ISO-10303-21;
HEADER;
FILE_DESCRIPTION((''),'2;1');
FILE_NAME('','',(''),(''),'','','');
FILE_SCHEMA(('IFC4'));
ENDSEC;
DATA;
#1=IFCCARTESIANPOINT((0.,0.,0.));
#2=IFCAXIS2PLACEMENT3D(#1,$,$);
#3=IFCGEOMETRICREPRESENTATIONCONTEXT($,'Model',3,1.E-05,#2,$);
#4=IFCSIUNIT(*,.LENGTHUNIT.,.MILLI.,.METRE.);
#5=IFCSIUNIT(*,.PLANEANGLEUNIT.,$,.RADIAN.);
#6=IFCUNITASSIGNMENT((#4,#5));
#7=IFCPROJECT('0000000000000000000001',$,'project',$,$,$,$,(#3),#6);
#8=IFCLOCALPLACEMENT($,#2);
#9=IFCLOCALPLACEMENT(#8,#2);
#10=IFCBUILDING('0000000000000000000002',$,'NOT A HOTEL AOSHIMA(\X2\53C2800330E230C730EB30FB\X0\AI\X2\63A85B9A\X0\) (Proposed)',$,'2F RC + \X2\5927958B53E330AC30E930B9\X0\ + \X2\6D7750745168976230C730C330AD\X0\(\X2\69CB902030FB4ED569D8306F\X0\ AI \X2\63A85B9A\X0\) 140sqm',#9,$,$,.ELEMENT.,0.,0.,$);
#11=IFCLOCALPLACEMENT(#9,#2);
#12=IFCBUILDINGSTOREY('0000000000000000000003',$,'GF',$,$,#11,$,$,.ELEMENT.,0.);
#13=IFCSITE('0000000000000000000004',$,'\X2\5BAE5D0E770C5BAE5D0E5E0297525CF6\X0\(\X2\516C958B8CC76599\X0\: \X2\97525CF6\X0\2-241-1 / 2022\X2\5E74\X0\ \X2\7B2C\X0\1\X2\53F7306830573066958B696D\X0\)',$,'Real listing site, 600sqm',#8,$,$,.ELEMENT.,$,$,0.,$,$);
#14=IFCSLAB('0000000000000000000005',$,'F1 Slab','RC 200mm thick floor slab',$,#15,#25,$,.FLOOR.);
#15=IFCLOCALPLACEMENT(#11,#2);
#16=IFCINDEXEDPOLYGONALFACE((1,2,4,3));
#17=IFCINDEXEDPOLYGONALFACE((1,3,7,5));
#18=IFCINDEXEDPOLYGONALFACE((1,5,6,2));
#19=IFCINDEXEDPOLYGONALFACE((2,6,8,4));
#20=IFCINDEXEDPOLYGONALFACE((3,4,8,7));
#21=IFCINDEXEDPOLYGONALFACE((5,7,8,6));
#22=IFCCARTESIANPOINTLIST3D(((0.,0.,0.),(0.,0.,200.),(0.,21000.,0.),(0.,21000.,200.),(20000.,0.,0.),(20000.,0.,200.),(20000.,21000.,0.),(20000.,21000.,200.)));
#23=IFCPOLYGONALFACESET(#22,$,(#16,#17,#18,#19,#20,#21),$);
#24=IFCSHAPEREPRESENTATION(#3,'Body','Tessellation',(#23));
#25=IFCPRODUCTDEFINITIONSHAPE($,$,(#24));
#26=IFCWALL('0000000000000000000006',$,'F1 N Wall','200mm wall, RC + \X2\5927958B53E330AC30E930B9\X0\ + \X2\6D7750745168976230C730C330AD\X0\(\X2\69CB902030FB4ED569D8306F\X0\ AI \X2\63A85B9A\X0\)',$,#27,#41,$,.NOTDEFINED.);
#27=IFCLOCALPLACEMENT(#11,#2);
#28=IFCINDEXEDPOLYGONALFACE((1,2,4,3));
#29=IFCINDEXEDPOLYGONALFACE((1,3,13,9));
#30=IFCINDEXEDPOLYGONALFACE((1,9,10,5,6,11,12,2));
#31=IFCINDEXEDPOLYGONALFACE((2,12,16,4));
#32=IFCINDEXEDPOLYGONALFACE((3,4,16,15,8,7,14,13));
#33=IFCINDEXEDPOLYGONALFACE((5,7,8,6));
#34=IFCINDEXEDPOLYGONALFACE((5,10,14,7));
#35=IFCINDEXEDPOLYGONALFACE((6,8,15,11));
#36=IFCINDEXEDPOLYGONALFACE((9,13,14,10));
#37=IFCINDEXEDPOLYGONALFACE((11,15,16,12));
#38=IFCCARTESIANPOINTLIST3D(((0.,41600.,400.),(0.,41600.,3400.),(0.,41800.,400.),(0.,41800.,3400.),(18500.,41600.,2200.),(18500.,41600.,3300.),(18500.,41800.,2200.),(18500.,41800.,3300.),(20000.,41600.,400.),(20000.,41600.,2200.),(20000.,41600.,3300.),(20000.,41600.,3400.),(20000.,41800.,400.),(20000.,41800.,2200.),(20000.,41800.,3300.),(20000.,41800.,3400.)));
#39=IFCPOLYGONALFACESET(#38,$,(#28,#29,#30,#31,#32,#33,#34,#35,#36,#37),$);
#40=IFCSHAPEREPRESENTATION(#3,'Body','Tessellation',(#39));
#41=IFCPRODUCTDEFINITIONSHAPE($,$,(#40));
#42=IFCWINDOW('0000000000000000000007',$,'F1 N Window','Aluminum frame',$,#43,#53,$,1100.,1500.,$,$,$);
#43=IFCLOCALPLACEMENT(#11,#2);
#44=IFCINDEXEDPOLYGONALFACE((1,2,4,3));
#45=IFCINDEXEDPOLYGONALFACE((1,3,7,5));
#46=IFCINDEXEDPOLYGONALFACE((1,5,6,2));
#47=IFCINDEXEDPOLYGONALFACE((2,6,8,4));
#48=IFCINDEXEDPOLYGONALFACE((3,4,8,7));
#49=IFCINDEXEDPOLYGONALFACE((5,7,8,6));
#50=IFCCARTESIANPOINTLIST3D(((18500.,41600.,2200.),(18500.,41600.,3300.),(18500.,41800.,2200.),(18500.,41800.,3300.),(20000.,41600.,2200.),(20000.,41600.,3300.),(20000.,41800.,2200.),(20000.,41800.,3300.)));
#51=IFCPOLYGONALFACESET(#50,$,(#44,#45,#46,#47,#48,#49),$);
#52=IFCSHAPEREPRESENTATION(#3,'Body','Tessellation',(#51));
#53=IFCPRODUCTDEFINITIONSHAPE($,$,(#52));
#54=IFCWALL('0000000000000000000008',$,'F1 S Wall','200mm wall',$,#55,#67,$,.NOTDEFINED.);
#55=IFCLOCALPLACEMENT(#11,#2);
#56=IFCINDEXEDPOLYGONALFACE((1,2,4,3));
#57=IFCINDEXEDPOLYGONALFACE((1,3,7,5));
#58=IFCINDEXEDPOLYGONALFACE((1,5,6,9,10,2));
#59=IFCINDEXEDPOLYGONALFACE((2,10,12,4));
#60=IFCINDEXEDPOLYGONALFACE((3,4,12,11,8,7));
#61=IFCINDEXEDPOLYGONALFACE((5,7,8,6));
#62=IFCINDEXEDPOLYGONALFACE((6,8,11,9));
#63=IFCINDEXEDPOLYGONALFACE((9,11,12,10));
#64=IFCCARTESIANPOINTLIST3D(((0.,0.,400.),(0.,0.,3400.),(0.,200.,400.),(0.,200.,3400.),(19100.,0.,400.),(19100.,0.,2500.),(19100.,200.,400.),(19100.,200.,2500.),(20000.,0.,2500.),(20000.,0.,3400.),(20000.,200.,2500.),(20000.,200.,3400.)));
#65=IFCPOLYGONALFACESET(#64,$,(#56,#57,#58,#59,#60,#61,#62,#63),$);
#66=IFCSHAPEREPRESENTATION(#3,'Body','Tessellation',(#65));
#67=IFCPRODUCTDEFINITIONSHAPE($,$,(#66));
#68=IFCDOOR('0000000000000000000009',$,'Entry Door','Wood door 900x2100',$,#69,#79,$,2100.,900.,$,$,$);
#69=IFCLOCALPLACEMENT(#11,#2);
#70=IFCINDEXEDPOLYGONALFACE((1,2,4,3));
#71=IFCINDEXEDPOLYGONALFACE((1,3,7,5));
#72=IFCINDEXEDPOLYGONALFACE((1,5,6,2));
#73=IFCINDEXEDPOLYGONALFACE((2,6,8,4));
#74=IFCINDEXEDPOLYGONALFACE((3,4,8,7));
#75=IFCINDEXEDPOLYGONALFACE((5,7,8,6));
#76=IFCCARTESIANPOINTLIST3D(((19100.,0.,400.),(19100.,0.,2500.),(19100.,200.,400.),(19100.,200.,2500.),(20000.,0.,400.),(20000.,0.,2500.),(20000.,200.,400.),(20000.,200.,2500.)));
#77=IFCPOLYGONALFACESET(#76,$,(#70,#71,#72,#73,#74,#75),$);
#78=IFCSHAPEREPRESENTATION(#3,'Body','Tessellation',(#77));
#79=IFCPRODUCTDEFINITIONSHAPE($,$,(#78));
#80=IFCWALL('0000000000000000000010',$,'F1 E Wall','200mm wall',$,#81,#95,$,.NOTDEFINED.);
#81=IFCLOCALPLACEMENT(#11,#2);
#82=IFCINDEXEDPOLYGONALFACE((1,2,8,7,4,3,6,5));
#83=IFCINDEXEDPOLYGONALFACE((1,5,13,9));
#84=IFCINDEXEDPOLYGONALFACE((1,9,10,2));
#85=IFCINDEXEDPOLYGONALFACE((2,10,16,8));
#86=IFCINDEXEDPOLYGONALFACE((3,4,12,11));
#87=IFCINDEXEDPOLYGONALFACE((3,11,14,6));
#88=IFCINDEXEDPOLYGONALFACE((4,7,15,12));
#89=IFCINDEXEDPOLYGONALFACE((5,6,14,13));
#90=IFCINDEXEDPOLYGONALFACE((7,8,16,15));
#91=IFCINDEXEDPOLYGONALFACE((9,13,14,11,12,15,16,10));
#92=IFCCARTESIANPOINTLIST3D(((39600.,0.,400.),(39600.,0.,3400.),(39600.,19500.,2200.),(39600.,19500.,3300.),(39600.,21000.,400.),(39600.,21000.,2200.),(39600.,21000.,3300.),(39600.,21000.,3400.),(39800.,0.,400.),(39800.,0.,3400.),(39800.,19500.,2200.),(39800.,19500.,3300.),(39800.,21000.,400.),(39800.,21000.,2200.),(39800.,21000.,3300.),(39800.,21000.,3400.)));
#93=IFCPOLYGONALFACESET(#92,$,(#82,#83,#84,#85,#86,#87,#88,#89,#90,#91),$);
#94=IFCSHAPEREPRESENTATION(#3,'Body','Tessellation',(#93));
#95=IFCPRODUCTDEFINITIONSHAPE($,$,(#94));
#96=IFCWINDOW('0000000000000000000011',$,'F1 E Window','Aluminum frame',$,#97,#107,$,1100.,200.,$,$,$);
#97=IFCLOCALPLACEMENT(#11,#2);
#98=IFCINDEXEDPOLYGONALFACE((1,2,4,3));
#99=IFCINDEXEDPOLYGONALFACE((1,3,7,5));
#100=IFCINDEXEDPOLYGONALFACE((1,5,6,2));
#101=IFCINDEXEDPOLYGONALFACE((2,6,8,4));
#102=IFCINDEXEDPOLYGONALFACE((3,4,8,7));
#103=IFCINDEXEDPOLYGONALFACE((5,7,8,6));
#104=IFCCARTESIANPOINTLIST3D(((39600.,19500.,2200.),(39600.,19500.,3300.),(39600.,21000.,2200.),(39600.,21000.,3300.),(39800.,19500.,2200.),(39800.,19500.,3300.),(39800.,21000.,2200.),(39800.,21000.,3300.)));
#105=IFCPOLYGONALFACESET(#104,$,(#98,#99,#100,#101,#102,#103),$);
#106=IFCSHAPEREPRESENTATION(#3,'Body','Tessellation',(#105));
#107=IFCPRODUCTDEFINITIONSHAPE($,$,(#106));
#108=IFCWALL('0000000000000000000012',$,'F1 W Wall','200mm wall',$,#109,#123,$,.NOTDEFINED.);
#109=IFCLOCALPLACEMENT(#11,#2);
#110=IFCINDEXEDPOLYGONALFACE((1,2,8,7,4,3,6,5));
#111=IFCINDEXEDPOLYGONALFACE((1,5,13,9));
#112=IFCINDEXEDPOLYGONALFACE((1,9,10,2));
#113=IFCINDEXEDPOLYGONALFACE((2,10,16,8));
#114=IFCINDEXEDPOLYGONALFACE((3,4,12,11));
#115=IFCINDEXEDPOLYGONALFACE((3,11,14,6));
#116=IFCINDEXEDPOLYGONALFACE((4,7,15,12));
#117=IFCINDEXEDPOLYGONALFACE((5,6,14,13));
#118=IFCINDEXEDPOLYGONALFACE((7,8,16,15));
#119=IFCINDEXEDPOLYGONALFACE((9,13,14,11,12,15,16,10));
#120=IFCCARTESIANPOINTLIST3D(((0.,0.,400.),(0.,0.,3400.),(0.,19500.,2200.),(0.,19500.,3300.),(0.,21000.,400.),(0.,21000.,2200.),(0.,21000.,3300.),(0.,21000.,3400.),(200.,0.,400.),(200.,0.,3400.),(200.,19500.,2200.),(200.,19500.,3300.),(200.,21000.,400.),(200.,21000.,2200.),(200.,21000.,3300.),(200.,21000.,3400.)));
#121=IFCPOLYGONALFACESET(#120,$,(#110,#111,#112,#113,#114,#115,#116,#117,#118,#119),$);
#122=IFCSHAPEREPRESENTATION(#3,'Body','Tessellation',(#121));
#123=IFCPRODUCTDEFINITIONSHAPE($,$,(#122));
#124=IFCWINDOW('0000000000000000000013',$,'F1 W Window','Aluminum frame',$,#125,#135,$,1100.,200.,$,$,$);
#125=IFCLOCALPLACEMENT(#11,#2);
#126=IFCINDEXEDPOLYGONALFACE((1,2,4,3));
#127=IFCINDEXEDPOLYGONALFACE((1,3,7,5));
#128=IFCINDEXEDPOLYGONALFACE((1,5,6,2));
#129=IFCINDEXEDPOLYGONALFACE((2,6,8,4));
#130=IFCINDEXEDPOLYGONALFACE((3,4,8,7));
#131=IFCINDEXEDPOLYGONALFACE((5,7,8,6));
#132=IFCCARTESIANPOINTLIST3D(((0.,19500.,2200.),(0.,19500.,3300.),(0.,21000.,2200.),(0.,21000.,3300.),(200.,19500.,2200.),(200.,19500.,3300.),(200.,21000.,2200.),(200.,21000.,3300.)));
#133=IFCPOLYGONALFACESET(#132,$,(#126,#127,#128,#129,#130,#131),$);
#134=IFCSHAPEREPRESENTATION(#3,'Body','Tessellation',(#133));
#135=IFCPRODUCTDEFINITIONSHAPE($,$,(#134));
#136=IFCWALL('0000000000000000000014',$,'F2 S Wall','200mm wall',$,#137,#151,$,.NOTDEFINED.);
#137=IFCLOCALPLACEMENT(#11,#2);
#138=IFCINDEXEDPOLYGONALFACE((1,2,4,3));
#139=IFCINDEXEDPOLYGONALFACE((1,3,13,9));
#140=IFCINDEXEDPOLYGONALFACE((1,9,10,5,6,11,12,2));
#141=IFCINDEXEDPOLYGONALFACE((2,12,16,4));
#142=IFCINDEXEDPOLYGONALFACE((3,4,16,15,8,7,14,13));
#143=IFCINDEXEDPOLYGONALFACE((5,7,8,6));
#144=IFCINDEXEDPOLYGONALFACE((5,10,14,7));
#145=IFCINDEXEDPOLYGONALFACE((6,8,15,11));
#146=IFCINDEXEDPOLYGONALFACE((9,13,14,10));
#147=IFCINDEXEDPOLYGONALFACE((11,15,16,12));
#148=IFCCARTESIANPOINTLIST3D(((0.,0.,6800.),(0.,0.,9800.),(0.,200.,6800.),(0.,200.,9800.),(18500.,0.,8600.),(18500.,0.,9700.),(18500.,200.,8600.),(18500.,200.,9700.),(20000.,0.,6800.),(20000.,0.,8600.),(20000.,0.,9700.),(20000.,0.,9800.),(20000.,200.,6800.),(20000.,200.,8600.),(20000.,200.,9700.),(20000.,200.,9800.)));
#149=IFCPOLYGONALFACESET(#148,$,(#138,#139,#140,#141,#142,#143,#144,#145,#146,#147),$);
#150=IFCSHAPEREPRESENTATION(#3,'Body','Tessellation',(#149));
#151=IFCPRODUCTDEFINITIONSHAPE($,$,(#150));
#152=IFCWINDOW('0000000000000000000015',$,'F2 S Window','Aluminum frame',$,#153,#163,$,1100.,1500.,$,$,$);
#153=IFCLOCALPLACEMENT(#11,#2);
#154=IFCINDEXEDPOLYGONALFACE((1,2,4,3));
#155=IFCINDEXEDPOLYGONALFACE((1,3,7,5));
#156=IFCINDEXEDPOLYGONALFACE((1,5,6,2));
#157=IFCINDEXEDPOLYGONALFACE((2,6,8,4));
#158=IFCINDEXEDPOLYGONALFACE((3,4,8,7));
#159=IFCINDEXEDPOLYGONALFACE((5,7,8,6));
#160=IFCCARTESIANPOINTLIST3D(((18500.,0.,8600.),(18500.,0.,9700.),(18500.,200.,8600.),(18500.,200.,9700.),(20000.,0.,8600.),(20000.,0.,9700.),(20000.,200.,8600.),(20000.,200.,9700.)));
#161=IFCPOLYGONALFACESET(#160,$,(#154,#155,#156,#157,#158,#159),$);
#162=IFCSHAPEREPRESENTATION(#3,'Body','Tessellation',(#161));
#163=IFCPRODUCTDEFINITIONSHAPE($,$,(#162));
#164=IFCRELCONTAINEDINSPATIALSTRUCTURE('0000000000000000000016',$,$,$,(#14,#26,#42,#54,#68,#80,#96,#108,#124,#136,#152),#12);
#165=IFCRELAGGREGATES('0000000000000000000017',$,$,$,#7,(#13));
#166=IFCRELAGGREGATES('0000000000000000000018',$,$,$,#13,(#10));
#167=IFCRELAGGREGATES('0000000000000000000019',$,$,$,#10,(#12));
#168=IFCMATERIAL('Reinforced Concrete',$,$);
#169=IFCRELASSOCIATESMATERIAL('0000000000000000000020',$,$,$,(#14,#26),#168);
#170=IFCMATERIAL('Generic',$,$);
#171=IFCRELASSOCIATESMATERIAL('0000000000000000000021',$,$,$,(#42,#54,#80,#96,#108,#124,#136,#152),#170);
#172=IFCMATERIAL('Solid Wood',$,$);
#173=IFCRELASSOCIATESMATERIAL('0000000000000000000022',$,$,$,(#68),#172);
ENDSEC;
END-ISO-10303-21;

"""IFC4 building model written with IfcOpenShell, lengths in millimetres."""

from ifc_helpers import new_model, si_unit, frame, frame_2d, origin, place, context, project, spatial, rectangle, extrude, material, element, fill, save


model = new_model("IFC4")

# Units and contexts
model_context = context("Model", 3, precision=1e-05, world=origin())
ifc_project = project(units=[si_unit("LENGTHUNIT", "METRE", prefix="MILLI"), si_unit("PLANEANGLEUNIT", "RADIAN")], contexts=[model_context])

# Site, building, storey
site_placement = place(None, origin())
site = spatial("IfcSite", under=ifc_project, at=site_placement, Name="宮崎県宮崎市青島(公開資料: 青島2-241-1 / 2022年 第1号として開業)", ObjectType="Real listing site, 600sqm", CompositionType="ELEMENT", RefElevation=0.0)
building_placement = place(site_placement, origin())
building = spatial("IfcBuilding", under=site, at=building_placement, Name="NOT A HOTEL AOSHIMA(参考モデル・AI推定) (Proposed)", ObjectType="2F RC + 大開口ガラス + 海側全面デッキ(構造・仕様は AI 推定) 140sqm", CompositionType="ELEMENT", ElevationOfRefHeight=0.0, ElevationOfTerrain=0.0)
storey_placement = place(building_placement, origin())
storey = spatial("IfcBuildingStorey", under=building, at=storey_placement, Name="GF", CompositionType="ELEMENT", Elevation=0.0)

# Slab
ifc_material_1 = material(Name="Reinforced Concrete")
slab_1_placement = place(storey_placement, origin())
element("IfcSlab", 1, at=slab_1_placement, inside=storey, material=ifc_material_1, Name="F1 Slab", Description="RC 200mm thick floor slab", PredefinedType="FLOOR", context=model_context, shape_type="SweptSolid", body=[
    extrude(rectangle(XDim=20000.0, YDim=21000.0, at=frame_2d((10000.0, 10500.0))), origin(), (0.0, 0.0, 1.0), 200.0),
])

# Wall, opening, window
wall_1_placement = place(storey_placement, frame((0.0, 20800.0, 200.0)))
wall_1 = element("IfcWall", 2, at=wall_1_placement, inside=storey, material=ifc_material_1, Name="F1 N Wall", Description="200mm wall, RC + 大開口ガラス + 海側全面デッキ(構造・仕様は AI 推定)", PredefinedType="NOTDEFINED", context=model_context, shape_type="SweptSolid", body=[
    extrude(rectangle(XDim=20000.0, YDim=200.0, at=frame_2d((10000.0, 100.0))), frame((0.0, 20800.0, 200.0)), (0.0, 0.0, 1.0), 3000.0),
])
opening_1_placement = place(storey_placement, frame((9250.0, 20800.0, 1100.0)))
opening_1 = element("IfcOpeningElement", 3, at=opening_1_placement, cuts=wall_1, PredefinedType="NOTDEFINED", context=model_context, shape_type="SweptSolid", body=[
    extrude(rectangle(XDim=1500.0, YDim=200.0, at=frame_2d((750.0, 100.0))), frame((9250.0, 20800.0, 1100.0)), (0.0, 0.0, 1.0), 1100.0),
])
ifc_material_2 = material(Name="Generic")
window_1_placement = place(storey_placement, frame((9250.0, 20800.0, 1100.0)))
window_1 = element("IfcWindow", 4, at=window_1_placement, inside=storey, material=ifc_material_2, Name="F1 N Window", Description="Aluminum frame", OverallHeight=1100.0, OverallWidth=1500.0, context=model_context, shape_type="SweptSolid", body=[
    extrude(rectangle(XDim=1500.0, YDim=200.0, at=frame_2d((750.0, 100.0))), frame((9250.0, 20800.0, 1100.0)), (0.0, 0.0, 1.0), 1100.0),
])
fill(opening_1, window_1)

# Wall, opening, door
wall_2_placement = place(storey_placement, frame((0.0, 0.0, 200.0)))
wall_2 = element("IfcWall", 5, at=wall_2_placement, inside=storey, material=ifc_material_2, Name="F1 S Wall", Description="200mm wall", PredefinedType="NOTDEFINED", context=model_context, shape_type="SweptSolid", body=[
    extrude(rectangle(XDim=20000.0, YDim=200.0, at=frame_2d((10000.0, 100.0))), frame((0.0, 0.0, 200.0)), (0.0, 0.0, 1.0), 3000.0),
])
opening_2_placement = place(storey_placement, frame((9550.0, 0.0, 200.0)))
opening_2 = element("IfcOpeningElement", 6, at=opening_2_placement, cuts=wall_2, PredefinedType="NOTDEFINED", context=model_context, shape_type="SweptSolid", body=[
    extrude(rectangle(XDim=900.0, YDim=200.0, at=frame_2d((450.0, 100.0))), frame((9550.0, 0.0, 200.0)), (0.0, 0.0, 1.0), 2100.0),
])
ifc_material_3 = material(Name="Solid Wood")
door_placement = place(storey_placement, frame((9550.0, 0.0, 200.0)))
door = element("IfcDoor", 7, at=door_placement, inside=storey, material=ifc_material_3, Name="Entry Door", Description="Wood door 900x2100", OverallHeight=2100.0, OverallWidth=900.0, context=model_context, shape_type="SweptSolid", body=[
    extrude(rectangle(XDim=900.0, YDim=200.0, at=frame_2d((450.0, 100.0))), frame((9550.0, 0.0, 200.0)), (0.0, 0.0, 1.0), 2100.0),
])
fill(opening_2, door)

# Walls, openings, windows
wall_3_placement = place(storey_placement, frame((19800.0, 0.0, 200.0)))
wall_3 = element("IfcWall", 8, at=wall_3_placement, inside=storey, material=ifc_material_2, Name="F1 E Wall", Description="200mm wall", PredefinedType="NOTDEFINED", context=model_context, shape_type="SweptSolid", body=[
    extrude(rectangle(XDim=200.0, YDim=21000.0, at=frame_2d((100.0, 10500.0))), frame((19800.0, 0.0, 200.0)), (0.0, 0.0, 1.0), 3000.0),
])
opening_3_placement = place(storey_placement, frame((19800.0, 9750.0, 1100.0)))
opening_3 = element("IfcOpeningElement", 9, at=opening_3_placement, cuts=wall_3, PredefinedType="NOTDEFINED", context=model_context, shape_type="SweptSolid", body=[
    extrude(rectangle(XDim=200.0, YDim=1500.0, at=frame_2d((100.0, 750.0))), frame((19800.0, 9750.0, 1100.0)), (0.0, 0.0, 1.0), 1100.0),
])
window_2_placement = place(storey_placement, frame((19800.0, 9750.0, 1100.0)))
window_2 = element("IfcWindow", 10, at=window_2_placement, inside=storey, material=ifc_material_2, Name="F1 E Window", Description="Aluminum frame", OverallHeight=1100.0, OverallWidth=200.0, context=model_context, shape_type="SweptSolid", body=[
    extrude(rectangle(XDim=200.0, YDim=1500.0, at=frame_2d((100.0, 750.0))), frame((19800.0, 9750.0, 1100.0)), (0.0, 0.0, 1.0), 1100.0),
])
fill(opening_3, window_2)
wall_4_placement = place(storey_placement, frame((0.0, 0.0, 200.0)))
wall_4 = element("IfcWall", 11, at=wall_4_placement, inside=storey, material=ifc_material_2, Name="F1 W Wall", Description="200mm wall", PredefinedType="NOTDEFINED", context=model_context, shape_type="SweptSolid", body=[
    extrude(rectangle(XDim=200.0, YDim=21000.0, at=frame_2d((100.0, 10500.0))), frame((0.0, 0.0, 200.0)), (0.0, 0.0, 1.0), 3000.0),
])
opening_4_placement = place(storey_placement, frame((0.0, 9750.0, 1100.0)))
opening_4 = element("IfcOpeningElement", 12, at=opening_4_placement, cuts=wall_4, PredefinedType="NOTDEFINED", context=model_context, shape_type="SweptSolid", body=[
    extrude(rectangle(XDim=200.0, YDim=1500.0, at=frame_2d((100.0, 750.0))), frame((0.0, 9750.0, 1100.0)), (0.0, 0.0, 1.0), 1100.0),
])
window_3_placement = place(storey_placement, frame((0.0, 9750.0, 1100.0)))
window_3 = element("IfcWindow", 13, at=window_3_placement, inside=storey, material=ifc_material_2, Name="F1 W Window", Description="Aluminum frame", OverallHeight=1100.0, OverallWidth=200.0, context=model_context, shape_type="SweptSolid", body=[
    extrude(rectangle(XDim=200.0, YDim=1500.0, at=frame_2d((100.0, 750.0))), frame((0.0, 9750.0, 1100.0)), (0.0, 0.0, 1.0), 1100.0),
])
fill(opening_4, window_3)
wall_5_placement = place(storey_placement, frame((0.0, 0.0, 3400.0)))
wall_5 = element("IfcWall", 14, at=wall_5_placement, inside=storey, material=ifc_material_2, Name="F2 S Wall", Description="200mm wall", PredefinedType="NOTDEFINED", context=model_context, shape_type="SweptSolid", body=[
    extrude(rectangle(XDim=20000.0, YDim=200.0, at=frame_2d((10000.0, 100.0))), frame((0.0, 0.0, 3400.0)), (0.0, 0.0, 1.0), 3000.0),
])
opening_5_placement = place(storey_placement, frame((9250.0, 0.0, 4300.0)))
opening_5 = element("IfcOpeningElement", 15, at=opening_5_placement, cuts=wall_5, PredefinedType="NOTDEFINED", context=model_context, shape_type="SweptSolid", body=[
    extrude(rectangle(XDim=1500.0, YDim=200.0, at=frame_2d((750.0, 100.0))), frame((9250.0, 0.0, 4300.0)), (0.0, 0.0, 1.0), 1100.0),
])
window_4_placement = place(storey_placement, frame((9250.0, 0.0, 4300.0)))
window_4 = element("IfcWindow", 16, at=window_4_placement, inside=storey, material=ifc_material_2, Name="F2 S Window", Description="Aluminum frame", OverallHeight=1100.0, OverallWidth=1500.0, context=model_context, shape_type="SweptSolid", body=[
    extrude(rectangle(XDim=1500.0, YDim=200.0, at=frame_2d((750.0, 100.0))), frame((9250.0, 0.0, 4300.0)), (0.0, 0.0, 1.0), 1100.0),
])
fill(opening_5, window_4)

save(model, "model.ifc")
